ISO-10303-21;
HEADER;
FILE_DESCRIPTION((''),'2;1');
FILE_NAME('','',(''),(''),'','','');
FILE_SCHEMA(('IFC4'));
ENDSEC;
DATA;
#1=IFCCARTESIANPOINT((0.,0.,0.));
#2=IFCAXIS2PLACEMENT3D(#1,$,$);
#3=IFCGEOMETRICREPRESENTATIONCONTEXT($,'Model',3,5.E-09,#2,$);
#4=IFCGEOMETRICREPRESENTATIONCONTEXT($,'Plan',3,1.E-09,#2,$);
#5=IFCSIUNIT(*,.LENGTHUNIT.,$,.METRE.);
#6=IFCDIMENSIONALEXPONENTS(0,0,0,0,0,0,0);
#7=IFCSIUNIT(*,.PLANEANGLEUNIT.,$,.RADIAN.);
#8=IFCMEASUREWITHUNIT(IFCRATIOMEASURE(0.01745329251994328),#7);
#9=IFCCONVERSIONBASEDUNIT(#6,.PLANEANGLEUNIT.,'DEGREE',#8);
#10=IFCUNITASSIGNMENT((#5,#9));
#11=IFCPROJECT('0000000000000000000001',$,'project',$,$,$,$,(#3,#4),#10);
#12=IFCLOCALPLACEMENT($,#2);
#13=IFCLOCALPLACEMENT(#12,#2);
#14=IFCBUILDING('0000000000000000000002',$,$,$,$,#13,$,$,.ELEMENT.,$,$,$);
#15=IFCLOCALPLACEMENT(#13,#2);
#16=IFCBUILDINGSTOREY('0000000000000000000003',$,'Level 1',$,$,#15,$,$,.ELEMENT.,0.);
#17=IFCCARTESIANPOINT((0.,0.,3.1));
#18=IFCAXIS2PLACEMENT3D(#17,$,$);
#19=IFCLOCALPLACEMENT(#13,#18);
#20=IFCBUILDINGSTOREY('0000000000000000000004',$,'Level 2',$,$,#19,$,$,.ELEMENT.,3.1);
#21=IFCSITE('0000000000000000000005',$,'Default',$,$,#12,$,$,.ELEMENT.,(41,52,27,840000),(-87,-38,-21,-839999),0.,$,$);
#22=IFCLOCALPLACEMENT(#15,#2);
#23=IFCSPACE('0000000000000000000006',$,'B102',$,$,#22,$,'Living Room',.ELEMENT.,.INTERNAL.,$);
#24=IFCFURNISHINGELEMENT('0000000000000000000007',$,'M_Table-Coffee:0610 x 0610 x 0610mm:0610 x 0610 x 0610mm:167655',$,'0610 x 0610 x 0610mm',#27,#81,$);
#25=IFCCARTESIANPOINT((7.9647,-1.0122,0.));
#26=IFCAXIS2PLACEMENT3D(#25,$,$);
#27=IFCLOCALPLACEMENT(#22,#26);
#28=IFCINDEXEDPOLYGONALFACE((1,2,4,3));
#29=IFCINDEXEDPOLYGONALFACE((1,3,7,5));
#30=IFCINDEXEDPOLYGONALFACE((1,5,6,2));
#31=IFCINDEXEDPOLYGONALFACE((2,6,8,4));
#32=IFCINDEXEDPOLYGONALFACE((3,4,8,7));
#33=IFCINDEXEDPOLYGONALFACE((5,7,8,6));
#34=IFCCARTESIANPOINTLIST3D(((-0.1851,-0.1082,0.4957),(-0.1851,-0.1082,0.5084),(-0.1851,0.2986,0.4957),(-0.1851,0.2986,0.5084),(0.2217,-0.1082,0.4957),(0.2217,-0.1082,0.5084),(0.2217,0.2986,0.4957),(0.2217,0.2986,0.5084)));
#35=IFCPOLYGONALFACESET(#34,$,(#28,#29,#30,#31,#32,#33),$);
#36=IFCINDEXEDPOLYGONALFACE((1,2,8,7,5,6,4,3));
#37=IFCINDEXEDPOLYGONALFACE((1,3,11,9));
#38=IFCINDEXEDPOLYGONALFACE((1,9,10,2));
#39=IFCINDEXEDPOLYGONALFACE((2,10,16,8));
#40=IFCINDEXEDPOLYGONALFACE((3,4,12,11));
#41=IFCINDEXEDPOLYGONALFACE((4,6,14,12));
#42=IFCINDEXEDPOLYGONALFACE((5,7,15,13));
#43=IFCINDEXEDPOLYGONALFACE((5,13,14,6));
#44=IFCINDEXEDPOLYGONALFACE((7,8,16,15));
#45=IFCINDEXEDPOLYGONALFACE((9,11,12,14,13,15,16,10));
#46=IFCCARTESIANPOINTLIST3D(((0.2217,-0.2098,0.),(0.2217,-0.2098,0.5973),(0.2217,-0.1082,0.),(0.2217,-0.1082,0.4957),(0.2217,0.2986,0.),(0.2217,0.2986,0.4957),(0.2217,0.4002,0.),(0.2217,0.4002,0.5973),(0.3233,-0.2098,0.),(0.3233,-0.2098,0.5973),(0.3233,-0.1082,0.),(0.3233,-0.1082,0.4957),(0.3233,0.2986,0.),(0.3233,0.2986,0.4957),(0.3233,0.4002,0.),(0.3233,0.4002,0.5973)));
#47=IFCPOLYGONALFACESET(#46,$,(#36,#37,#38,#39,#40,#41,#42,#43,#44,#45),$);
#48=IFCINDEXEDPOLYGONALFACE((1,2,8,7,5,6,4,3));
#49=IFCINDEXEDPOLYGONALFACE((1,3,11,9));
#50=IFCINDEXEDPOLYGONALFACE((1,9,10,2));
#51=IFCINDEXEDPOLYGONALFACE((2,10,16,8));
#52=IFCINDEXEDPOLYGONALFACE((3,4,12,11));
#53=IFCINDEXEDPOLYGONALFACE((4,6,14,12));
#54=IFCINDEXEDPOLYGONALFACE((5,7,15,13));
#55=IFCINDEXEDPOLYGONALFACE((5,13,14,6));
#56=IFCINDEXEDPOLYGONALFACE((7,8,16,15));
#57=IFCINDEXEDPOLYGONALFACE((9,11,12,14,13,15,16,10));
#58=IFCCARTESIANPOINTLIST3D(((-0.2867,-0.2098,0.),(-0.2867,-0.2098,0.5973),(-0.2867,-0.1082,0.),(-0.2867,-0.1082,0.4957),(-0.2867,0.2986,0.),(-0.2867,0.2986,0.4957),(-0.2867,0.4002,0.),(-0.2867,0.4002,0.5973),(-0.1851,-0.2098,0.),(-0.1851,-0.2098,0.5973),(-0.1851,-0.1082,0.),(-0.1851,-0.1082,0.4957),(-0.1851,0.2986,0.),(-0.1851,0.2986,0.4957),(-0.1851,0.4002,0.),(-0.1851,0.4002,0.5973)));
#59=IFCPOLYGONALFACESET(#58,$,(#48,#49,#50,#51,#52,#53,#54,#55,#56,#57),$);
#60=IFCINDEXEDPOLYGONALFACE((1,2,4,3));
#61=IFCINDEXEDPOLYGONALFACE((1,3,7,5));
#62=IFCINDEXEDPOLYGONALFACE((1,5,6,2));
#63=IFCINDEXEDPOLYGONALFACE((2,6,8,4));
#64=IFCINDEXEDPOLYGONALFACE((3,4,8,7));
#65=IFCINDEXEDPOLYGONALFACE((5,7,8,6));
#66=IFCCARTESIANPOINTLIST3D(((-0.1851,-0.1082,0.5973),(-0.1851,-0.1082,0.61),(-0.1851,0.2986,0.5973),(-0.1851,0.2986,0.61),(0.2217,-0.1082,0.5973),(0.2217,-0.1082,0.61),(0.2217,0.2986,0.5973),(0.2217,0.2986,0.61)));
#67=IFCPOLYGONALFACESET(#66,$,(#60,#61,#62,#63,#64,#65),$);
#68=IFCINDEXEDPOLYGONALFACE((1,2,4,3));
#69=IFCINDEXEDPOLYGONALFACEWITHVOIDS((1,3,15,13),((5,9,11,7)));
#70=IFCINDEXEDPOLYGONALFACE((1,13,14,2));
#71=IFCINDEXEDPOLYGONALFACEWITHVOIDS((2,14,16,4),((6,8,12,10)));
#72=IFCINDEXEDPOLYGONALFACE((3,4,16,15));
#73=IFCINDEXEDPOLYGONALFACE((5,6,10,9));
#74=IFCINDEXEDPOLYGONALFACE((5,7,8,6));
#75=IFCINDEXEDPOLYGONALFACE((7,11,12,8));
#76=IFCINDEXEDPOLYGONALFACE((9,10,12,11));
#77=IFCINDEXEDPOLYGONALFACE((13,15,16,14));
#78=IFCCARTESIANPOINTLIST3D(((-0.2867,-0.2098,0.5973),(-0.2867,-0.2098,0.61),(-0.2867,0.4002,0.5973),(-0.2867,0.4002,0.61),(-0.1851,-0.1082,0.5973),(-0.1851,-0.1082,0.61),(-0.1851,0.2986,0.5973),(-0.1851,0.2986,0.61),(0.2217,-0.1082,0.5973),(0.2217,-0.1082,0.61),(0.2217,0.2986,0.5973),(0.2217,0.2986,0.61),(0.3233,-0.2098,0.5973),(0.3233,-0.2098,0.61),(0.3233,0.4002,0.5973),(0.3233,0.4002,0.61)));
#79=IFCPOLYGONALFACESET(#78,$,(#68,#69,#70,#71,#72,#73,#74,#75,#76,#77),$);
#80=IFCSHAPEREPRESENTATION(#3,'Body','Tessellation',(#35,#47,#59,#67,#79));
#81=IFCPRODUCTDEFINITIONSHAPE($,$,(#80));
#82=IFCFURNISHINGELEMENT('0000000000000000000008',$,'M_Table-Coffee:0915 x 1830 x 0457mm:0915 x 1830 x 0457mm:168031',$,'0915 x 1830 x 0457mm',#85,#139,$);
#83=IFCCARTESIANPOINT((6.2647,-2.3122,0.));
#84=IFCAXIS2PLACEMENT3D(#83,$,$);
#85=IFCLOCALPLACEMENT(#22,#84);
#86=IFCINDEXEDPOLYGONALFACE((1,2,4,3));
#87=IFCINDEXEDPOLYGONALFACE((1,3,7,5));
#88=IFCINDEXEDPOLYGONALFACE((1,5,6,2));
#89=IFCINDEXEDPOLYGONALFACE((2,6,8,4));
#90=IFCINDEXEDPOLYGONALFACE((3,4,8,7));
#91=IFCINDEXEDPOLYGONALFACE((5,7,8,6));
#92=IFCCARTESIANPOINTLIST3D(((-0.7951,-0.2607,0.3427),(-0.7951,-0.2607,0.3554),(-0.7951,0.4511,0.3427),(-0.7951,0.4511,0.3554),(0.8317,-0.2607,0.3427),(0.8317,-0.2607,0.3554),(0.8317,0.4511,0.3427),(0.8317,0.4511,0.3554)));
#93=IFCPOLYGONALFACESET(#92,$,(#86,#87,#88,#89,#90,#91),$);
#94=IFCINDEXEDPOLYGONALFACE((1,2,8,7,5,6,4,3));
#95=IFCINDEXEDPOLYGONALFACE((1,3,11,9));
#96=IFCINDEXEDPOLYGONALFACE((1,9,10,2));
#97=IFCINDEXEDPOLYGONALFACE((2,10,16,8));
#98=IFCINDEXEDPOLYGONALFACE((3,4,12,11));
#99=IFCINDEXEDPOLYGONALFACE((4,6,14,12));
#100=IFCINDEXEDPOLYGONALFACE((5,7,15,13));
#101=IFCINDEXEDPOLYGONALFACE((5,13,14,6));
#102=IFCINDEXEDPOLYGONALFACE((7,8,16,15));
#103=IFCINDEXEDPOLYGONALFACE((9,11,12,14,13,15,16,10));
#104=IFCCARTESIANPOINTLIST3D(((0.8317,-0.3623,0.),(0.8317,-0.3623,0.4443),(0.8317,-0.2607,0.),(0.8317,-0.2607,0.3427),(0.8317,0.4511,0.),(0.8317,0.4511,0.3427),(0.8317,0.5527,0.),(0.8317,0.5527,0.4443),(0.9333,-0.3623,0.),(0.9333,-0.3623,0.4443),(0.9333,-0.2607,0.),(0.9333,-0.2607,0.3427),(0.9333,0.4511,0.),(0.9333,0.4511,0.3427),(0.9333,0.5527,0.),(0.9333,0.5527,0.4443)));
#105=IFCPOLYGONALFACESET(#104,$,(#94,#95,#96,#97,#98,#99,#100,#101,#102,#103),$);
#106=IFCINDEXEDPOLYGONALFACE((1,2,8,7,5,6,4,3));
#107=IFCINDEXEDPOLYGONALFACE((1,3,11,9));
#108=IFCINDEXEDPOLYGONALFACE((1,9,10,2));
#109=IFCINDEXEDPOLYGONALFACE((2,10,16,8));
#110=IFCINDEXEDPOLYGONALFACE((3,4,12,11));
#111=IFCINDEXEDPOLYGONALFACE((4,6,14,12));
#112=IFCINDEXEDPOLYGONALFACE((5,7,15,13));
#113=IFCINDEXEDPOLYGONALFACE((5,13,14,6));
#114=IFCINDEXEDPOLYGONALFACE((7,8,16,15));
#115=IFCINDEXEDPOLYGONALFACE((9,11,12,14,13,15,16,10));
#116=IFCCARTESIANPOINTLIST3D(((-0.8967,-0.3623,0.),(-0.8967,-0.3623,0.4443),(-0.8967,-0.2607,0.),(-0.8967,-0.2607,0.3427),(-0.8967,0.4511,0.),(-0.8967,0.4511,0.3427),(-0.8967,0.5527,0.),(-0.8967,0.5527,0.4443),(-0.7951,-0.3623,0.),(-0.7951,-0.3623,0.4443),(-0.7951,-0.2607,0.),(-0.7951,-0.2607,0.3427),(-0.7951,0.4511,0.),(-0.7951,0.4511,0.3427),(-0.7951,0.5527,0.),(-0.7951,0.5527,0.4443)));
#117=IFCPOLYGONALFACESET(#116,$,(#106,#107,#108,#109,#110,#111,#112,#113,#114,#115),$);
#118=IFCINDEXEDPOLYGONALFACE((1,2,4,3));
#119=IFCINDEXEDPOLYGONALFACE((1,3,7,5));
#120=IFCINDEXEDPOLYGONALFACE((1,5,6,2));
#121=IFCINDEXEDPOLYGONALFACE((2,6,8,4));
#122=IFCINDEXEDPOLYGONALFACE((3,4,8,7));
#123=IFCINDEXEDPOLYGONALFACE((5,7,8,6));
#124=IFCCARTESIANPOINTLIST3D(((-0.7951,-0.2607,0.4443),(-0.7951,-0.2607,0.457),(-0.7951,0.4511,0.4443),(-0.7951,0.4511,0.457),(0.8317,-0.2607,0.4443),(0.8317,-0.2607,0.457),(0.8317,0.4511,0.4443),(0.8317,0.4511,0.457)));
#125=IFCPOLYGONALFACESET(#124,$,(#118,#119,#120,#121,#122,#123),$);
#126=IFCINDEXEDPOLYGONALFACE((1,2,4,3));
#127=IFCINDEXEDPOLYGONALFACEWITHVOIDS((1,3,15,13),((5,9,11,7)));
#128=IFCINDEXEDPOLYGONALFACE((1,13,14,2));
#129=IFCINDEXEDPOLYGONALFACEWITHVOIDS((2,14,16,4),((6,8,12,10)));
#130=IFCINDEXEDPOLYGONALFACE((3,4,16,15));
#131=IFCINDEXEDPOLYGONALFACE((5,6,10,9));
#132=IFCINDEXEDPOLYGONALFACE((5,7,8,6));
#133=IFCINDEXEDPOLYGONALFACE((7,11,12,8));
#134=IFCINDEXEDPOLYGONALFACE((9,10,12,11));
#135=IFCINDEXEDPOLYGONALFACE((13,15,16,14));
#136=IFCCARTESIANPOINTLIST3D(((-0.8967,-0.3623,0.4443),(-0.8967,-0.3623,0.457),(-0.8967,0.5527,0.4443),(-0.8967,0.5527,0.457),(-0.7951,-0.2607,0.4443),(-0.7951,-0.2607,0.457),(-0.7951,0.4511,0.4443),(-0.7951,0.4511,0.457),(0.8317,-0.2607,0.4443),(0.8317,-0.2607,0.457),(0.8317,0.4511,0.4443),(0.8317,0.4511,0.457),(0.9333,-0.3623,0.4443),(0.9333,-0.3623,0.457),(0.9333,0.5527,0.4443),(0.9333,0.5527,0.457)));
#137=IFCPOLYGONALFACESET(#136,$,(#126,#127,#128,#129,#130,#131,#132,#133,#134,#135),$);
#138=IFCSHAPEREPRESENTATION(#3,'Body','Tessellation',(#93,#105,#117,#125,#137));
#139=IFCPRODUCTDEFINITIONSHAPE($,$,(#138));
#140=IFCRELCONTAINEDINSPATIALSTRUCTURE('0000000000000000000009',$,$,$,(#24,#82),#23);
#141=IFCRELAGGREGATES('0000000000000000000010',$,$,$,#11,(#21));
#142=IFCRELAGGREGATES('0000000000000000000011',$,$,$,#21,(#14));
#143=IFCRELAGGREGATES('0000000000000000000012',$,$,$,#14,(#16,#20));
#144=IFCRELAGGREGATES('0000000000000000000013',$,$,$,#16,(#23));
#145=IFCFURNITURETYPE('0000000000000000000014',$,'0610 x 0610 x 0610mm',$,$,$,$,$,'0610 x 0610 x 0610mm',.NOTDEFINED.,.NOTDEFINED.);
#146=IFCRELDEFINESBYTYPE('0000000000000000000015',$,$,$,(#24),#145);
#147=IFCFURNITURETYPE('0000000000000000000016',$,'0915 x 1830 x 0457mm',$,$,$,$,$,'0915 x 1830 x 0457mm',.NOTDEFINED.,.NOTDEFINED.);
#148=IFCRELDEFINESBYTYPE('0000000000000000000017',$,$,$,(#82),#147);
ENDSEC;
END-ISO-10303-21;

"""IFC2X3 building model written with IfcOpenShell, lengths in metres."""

from ifc_helpers import new_model, entity, si_unit, converted_unit, frame, origin, origin_2d_with_axis, place, context, project, spatial, polyline, rectangle, outline, extrude, source, transform, mapped, type_object, type_shapes, element, save


model = new_model("IFC2X3")

# Units and contexts
model_context = context("Model", 3, precision=5e-09, world=origin())
plan_context = context("Plan", 3, precision=1e-09, world=origin())
ifc_project = project(units=[si_unit("LENGTHUNIT", "METRE"), converted_unit("PLANEANGLEUNIT", "DEGREE", entity("IfcRatioMeasure", 0.01745329251994328), si_unit("PLANEANGLEUNIT", "RADIAN"), dimensions=[0, 0, 0, 0, 0, 0, 0])], contexts=[model_context, plan_context])

# Site, building, storey
site_placement = place(None, origin())
site = spatial("IfcSite", under=ifc_project, at=site_placement, Name="Default", CompositionType="ELEMENT", RefLatitude=(41, 52, 27, 840000), RefLongitude=(-87, -38, -21, -839999), RefElevation=0.0)
building_placement = place(site_placement, origin())
building = spatial("IfcBuilding", under=site, at=building_placement, CompositionType="ELEMENT")
storey_1_placement = place(building_placement, origin())
storey_1 = spatial("IfcBuildingStorey", under=building, at=storey_1_placement, Name="Level 1", CompositionType="ELEMENT", Elevation=0.0)

# Shared definitions
storey_2_placement = place(building_placement, frame((0.0, 0.0, 3.1)))
storey_2 = spatial("IfcBuildingStorey", under=building, at=storey_2_placement, Name="Level 2", CompositionType="ELEMENT", Elevation=3.1)

# Shared definitions
space_1_placement = place(storey_1_placement, origin())
space_1 = spatial("IfcSpace", under=storey_1, at=space_1_placement, Name="B102", LongName="Living Room", CompositionType="ELEMENT", InteriorOrExteriorSpace="INTERNAL")

# Furnishing element
furniture_type_1 = type_object("IfcFurnitureType", Name="0610 x 0610 x 0610mm", ElementType="0610 x 0610 x 0610mm", AssemblyPlace="NOTDEFINED")
shared_shape_1 = source(origin(), model_context, "Body", "SweptSolid", [
    extrude(rectangle(XDim=0.4068, YDim=0.4068, at=origin_2d_with_axis()), frame((0.0183, 0.0952, 0.4957), z_axis=(0.0, 0.0, 1.0), x_axis=(-1.0, 0.0, 0.0)), (0.0, 0.0, 1.0), 0.0127),
    extrude(outline(polyline([(-0.2732, -0.305), (0.324, -0.305), (0.324, 0.305), (-0.2732, 0.305), (-0.2732, 0.2034), (0.2225, 0.2034), (0.2225, -0.2034), (-0.2732, -0.2034), (-0.2732, -0.305)])), frame((0.2217, 0.0952, 0.2732), z_axis=(1.0, 0.0, 0.0), x_axis=(0.0, 0.0, 1.0)), (0.0, 0.0, 1.0), 0.1016),
    extrude(outline(polyline([(-0.305, -0.3241), (0.305, -0.3241), (0.305, 0.2733), (0.2034, 0.2733), (0.2034, -0.2224), (-0.2034, -0.2224), (-0.2034, 0.2733), (-0.305, 0.2733), (-0.305, -0.3241)])), frame((-0.2867, 0.0952, 0.2733), z_axis=(1.0, 0.0, 0.0), x_axis=(0.0, -1.0, 0.0)), (0.0, 0.0, 1.0), 0.1016),
    extrude(rectangle(XDim=0.4068, YDim=0.4068, at=origin_2d_with_axis()), frame((0.0183, 0.0952, 0.5973), z_axis=(0.0, 0.0, 1.0), x_axis=(-1.0, 0.0, 0.0)), (0.0, 0.0, 1.0), 0.0127),
    extrude(outline(polyline([(-0.305, -0.305), (0.305, -0.305), (0.305, 0.305), (-0.305, 0.305), (-0.305, -0.305)]), holes=[polyline([(-0.2034, -0.2034), (-0.2034, 0.2034), (0.2034, 0.2034), (0.2034, -0.2034), (-0.2034, -0.2034)])]), frame((0.0183, 0.0952, 0.5973), z_axis=(0.0, 0.0, 1.0), x_axis=(-1.0, 0.0, 0.0)), (0.0, 0.0, 1.0), 0.0127),
])
type_shapes(furniture_type_1, [shared_shape_1])
for number, where, name in (
    (1, (7.9647, -1.0122, 0.0), "M_Table-Coffee:0610 x 0610 x 0610mm:0610 x 0610 x 0610mm:167655"),
):
    element("IfcFurnishingElement", number, at=place(space_1_placement, frame(where)), inside=space_1, type_object=furniture_type_1, Name=name, ObjectType="0610 x 0610 x 0610mm", context=model_context, shape_type="MappedRepresentation", body=[
        mapped(shared_shape_1, transform((0.0, 0.0, 0.0), scale=1.0)),
    ])

# Furnishing element
furniture_type_2 = type_object("IfcFurnitureType", Name="0915 x 1830 x 0457mm", ElementType="0915 x 1830 x 0457mm", AssemblyPlace="NOTDEFINED")
shared_shape_2 = source(origin(), model_context, "Body", "SweptSolid", [
    extrude(rectangle(XDim=1.6268, YDim=0.7118, at=origin_2d_with_axis()), frame((0.0183, 0.0952, 0.3427), z_axis=(0.0, 0.0, 1.0), x_axis=(-1.0, 0.0, 0.0)), (0.0, 0.0, 1.0), 0.0127),
    extrude(outline(polyline([(-0.1967, -0.4575), (0.2475, -0.4575), (0.2475, 0.4575), (-0.1967, 0.4575), (-0.1967, 0.3559), (0.146, 0.3559), (0.146, -0.3559), (-0.1967, -0.3559), (-0.1967, -0.4575)])), frame((0.8317, 0.0952, 0.1967), z_axis=(1.0, 0.0, 0.0), x_axis=(0.0, 0.0, 1.0)), (0.0, 0.0, 1.0), 0.1016),
    extrude(outline(polyline([(-0.4575, -0.2476), (0.4575, -0.2476), (0.4575, 0.1968), (0.3559, 0.1968), (0.3559, -0.1459), (-0.3559, -0.1459), (-0.3559, 0.1968), (-0.4575, 0.1968), (-0.4575, -0.2476)])), frame((-0.8967, 0.0952, 0.1968), z_axis=(1.0, 0.0, 0.0), x_axis=(0.0, -1.0, 0.0)), (0.0, 0.0, 1.0), 0.1016),
    extrude(rectangle(XDim=1.6268, YDim=0.7118, at=origin_2d_with_axis()), frame((0.0183, 0.0952, 0.4443), z_axis=(0.0, 0.0, 1.0), x_axis=(-1.0, 0.0, 0.0)), (0.0, 0.0, 1.0), 0.0127),
    extrude(outline(polyline([(-0.915, -0.4575), (0.915, -0.4575), (0.915, 0.4575), (-0.915, 0.4575), (-0.915, -0.4575)]), holes=[polyline([(-0.8134, -0.3559), (-0.8134, 0.3559), (0.8134, 0.3559), (0.8134, -0.3559), (-0.8134, -0.3559)])]), frame((0.0183, 0.0952, 0.4443), z_axis=(0.0, 0.0, 1.0), x_axis=(-1.0, 0.0, 0.0)), (0.0, 0.0, 1.0), 0.0127),
])
type_shapes(furniture_type_2, [shared_shape_2])
furnishing_1_placement = place(space_1_placement, frame((6.2647, -2.3122, 0.0)))
element("IfcFurnishingElement", 2, at=furnishing_1_placement, inside=space_1, type_object=furniture_type_2, Name="M_Table-Coffee:0915 x 1830 x 0457mm:0915 x 1830 x 0457mm:168031", ObjectType="0915 x 1830 x 0457mm", context=model_context, shape_type="MappedRepresentation", body=[
    mapped(shared_shape_2, transform((0.0, 0.0, 0.0), scale=1.0)),
])

save(model, "model.ifc")
